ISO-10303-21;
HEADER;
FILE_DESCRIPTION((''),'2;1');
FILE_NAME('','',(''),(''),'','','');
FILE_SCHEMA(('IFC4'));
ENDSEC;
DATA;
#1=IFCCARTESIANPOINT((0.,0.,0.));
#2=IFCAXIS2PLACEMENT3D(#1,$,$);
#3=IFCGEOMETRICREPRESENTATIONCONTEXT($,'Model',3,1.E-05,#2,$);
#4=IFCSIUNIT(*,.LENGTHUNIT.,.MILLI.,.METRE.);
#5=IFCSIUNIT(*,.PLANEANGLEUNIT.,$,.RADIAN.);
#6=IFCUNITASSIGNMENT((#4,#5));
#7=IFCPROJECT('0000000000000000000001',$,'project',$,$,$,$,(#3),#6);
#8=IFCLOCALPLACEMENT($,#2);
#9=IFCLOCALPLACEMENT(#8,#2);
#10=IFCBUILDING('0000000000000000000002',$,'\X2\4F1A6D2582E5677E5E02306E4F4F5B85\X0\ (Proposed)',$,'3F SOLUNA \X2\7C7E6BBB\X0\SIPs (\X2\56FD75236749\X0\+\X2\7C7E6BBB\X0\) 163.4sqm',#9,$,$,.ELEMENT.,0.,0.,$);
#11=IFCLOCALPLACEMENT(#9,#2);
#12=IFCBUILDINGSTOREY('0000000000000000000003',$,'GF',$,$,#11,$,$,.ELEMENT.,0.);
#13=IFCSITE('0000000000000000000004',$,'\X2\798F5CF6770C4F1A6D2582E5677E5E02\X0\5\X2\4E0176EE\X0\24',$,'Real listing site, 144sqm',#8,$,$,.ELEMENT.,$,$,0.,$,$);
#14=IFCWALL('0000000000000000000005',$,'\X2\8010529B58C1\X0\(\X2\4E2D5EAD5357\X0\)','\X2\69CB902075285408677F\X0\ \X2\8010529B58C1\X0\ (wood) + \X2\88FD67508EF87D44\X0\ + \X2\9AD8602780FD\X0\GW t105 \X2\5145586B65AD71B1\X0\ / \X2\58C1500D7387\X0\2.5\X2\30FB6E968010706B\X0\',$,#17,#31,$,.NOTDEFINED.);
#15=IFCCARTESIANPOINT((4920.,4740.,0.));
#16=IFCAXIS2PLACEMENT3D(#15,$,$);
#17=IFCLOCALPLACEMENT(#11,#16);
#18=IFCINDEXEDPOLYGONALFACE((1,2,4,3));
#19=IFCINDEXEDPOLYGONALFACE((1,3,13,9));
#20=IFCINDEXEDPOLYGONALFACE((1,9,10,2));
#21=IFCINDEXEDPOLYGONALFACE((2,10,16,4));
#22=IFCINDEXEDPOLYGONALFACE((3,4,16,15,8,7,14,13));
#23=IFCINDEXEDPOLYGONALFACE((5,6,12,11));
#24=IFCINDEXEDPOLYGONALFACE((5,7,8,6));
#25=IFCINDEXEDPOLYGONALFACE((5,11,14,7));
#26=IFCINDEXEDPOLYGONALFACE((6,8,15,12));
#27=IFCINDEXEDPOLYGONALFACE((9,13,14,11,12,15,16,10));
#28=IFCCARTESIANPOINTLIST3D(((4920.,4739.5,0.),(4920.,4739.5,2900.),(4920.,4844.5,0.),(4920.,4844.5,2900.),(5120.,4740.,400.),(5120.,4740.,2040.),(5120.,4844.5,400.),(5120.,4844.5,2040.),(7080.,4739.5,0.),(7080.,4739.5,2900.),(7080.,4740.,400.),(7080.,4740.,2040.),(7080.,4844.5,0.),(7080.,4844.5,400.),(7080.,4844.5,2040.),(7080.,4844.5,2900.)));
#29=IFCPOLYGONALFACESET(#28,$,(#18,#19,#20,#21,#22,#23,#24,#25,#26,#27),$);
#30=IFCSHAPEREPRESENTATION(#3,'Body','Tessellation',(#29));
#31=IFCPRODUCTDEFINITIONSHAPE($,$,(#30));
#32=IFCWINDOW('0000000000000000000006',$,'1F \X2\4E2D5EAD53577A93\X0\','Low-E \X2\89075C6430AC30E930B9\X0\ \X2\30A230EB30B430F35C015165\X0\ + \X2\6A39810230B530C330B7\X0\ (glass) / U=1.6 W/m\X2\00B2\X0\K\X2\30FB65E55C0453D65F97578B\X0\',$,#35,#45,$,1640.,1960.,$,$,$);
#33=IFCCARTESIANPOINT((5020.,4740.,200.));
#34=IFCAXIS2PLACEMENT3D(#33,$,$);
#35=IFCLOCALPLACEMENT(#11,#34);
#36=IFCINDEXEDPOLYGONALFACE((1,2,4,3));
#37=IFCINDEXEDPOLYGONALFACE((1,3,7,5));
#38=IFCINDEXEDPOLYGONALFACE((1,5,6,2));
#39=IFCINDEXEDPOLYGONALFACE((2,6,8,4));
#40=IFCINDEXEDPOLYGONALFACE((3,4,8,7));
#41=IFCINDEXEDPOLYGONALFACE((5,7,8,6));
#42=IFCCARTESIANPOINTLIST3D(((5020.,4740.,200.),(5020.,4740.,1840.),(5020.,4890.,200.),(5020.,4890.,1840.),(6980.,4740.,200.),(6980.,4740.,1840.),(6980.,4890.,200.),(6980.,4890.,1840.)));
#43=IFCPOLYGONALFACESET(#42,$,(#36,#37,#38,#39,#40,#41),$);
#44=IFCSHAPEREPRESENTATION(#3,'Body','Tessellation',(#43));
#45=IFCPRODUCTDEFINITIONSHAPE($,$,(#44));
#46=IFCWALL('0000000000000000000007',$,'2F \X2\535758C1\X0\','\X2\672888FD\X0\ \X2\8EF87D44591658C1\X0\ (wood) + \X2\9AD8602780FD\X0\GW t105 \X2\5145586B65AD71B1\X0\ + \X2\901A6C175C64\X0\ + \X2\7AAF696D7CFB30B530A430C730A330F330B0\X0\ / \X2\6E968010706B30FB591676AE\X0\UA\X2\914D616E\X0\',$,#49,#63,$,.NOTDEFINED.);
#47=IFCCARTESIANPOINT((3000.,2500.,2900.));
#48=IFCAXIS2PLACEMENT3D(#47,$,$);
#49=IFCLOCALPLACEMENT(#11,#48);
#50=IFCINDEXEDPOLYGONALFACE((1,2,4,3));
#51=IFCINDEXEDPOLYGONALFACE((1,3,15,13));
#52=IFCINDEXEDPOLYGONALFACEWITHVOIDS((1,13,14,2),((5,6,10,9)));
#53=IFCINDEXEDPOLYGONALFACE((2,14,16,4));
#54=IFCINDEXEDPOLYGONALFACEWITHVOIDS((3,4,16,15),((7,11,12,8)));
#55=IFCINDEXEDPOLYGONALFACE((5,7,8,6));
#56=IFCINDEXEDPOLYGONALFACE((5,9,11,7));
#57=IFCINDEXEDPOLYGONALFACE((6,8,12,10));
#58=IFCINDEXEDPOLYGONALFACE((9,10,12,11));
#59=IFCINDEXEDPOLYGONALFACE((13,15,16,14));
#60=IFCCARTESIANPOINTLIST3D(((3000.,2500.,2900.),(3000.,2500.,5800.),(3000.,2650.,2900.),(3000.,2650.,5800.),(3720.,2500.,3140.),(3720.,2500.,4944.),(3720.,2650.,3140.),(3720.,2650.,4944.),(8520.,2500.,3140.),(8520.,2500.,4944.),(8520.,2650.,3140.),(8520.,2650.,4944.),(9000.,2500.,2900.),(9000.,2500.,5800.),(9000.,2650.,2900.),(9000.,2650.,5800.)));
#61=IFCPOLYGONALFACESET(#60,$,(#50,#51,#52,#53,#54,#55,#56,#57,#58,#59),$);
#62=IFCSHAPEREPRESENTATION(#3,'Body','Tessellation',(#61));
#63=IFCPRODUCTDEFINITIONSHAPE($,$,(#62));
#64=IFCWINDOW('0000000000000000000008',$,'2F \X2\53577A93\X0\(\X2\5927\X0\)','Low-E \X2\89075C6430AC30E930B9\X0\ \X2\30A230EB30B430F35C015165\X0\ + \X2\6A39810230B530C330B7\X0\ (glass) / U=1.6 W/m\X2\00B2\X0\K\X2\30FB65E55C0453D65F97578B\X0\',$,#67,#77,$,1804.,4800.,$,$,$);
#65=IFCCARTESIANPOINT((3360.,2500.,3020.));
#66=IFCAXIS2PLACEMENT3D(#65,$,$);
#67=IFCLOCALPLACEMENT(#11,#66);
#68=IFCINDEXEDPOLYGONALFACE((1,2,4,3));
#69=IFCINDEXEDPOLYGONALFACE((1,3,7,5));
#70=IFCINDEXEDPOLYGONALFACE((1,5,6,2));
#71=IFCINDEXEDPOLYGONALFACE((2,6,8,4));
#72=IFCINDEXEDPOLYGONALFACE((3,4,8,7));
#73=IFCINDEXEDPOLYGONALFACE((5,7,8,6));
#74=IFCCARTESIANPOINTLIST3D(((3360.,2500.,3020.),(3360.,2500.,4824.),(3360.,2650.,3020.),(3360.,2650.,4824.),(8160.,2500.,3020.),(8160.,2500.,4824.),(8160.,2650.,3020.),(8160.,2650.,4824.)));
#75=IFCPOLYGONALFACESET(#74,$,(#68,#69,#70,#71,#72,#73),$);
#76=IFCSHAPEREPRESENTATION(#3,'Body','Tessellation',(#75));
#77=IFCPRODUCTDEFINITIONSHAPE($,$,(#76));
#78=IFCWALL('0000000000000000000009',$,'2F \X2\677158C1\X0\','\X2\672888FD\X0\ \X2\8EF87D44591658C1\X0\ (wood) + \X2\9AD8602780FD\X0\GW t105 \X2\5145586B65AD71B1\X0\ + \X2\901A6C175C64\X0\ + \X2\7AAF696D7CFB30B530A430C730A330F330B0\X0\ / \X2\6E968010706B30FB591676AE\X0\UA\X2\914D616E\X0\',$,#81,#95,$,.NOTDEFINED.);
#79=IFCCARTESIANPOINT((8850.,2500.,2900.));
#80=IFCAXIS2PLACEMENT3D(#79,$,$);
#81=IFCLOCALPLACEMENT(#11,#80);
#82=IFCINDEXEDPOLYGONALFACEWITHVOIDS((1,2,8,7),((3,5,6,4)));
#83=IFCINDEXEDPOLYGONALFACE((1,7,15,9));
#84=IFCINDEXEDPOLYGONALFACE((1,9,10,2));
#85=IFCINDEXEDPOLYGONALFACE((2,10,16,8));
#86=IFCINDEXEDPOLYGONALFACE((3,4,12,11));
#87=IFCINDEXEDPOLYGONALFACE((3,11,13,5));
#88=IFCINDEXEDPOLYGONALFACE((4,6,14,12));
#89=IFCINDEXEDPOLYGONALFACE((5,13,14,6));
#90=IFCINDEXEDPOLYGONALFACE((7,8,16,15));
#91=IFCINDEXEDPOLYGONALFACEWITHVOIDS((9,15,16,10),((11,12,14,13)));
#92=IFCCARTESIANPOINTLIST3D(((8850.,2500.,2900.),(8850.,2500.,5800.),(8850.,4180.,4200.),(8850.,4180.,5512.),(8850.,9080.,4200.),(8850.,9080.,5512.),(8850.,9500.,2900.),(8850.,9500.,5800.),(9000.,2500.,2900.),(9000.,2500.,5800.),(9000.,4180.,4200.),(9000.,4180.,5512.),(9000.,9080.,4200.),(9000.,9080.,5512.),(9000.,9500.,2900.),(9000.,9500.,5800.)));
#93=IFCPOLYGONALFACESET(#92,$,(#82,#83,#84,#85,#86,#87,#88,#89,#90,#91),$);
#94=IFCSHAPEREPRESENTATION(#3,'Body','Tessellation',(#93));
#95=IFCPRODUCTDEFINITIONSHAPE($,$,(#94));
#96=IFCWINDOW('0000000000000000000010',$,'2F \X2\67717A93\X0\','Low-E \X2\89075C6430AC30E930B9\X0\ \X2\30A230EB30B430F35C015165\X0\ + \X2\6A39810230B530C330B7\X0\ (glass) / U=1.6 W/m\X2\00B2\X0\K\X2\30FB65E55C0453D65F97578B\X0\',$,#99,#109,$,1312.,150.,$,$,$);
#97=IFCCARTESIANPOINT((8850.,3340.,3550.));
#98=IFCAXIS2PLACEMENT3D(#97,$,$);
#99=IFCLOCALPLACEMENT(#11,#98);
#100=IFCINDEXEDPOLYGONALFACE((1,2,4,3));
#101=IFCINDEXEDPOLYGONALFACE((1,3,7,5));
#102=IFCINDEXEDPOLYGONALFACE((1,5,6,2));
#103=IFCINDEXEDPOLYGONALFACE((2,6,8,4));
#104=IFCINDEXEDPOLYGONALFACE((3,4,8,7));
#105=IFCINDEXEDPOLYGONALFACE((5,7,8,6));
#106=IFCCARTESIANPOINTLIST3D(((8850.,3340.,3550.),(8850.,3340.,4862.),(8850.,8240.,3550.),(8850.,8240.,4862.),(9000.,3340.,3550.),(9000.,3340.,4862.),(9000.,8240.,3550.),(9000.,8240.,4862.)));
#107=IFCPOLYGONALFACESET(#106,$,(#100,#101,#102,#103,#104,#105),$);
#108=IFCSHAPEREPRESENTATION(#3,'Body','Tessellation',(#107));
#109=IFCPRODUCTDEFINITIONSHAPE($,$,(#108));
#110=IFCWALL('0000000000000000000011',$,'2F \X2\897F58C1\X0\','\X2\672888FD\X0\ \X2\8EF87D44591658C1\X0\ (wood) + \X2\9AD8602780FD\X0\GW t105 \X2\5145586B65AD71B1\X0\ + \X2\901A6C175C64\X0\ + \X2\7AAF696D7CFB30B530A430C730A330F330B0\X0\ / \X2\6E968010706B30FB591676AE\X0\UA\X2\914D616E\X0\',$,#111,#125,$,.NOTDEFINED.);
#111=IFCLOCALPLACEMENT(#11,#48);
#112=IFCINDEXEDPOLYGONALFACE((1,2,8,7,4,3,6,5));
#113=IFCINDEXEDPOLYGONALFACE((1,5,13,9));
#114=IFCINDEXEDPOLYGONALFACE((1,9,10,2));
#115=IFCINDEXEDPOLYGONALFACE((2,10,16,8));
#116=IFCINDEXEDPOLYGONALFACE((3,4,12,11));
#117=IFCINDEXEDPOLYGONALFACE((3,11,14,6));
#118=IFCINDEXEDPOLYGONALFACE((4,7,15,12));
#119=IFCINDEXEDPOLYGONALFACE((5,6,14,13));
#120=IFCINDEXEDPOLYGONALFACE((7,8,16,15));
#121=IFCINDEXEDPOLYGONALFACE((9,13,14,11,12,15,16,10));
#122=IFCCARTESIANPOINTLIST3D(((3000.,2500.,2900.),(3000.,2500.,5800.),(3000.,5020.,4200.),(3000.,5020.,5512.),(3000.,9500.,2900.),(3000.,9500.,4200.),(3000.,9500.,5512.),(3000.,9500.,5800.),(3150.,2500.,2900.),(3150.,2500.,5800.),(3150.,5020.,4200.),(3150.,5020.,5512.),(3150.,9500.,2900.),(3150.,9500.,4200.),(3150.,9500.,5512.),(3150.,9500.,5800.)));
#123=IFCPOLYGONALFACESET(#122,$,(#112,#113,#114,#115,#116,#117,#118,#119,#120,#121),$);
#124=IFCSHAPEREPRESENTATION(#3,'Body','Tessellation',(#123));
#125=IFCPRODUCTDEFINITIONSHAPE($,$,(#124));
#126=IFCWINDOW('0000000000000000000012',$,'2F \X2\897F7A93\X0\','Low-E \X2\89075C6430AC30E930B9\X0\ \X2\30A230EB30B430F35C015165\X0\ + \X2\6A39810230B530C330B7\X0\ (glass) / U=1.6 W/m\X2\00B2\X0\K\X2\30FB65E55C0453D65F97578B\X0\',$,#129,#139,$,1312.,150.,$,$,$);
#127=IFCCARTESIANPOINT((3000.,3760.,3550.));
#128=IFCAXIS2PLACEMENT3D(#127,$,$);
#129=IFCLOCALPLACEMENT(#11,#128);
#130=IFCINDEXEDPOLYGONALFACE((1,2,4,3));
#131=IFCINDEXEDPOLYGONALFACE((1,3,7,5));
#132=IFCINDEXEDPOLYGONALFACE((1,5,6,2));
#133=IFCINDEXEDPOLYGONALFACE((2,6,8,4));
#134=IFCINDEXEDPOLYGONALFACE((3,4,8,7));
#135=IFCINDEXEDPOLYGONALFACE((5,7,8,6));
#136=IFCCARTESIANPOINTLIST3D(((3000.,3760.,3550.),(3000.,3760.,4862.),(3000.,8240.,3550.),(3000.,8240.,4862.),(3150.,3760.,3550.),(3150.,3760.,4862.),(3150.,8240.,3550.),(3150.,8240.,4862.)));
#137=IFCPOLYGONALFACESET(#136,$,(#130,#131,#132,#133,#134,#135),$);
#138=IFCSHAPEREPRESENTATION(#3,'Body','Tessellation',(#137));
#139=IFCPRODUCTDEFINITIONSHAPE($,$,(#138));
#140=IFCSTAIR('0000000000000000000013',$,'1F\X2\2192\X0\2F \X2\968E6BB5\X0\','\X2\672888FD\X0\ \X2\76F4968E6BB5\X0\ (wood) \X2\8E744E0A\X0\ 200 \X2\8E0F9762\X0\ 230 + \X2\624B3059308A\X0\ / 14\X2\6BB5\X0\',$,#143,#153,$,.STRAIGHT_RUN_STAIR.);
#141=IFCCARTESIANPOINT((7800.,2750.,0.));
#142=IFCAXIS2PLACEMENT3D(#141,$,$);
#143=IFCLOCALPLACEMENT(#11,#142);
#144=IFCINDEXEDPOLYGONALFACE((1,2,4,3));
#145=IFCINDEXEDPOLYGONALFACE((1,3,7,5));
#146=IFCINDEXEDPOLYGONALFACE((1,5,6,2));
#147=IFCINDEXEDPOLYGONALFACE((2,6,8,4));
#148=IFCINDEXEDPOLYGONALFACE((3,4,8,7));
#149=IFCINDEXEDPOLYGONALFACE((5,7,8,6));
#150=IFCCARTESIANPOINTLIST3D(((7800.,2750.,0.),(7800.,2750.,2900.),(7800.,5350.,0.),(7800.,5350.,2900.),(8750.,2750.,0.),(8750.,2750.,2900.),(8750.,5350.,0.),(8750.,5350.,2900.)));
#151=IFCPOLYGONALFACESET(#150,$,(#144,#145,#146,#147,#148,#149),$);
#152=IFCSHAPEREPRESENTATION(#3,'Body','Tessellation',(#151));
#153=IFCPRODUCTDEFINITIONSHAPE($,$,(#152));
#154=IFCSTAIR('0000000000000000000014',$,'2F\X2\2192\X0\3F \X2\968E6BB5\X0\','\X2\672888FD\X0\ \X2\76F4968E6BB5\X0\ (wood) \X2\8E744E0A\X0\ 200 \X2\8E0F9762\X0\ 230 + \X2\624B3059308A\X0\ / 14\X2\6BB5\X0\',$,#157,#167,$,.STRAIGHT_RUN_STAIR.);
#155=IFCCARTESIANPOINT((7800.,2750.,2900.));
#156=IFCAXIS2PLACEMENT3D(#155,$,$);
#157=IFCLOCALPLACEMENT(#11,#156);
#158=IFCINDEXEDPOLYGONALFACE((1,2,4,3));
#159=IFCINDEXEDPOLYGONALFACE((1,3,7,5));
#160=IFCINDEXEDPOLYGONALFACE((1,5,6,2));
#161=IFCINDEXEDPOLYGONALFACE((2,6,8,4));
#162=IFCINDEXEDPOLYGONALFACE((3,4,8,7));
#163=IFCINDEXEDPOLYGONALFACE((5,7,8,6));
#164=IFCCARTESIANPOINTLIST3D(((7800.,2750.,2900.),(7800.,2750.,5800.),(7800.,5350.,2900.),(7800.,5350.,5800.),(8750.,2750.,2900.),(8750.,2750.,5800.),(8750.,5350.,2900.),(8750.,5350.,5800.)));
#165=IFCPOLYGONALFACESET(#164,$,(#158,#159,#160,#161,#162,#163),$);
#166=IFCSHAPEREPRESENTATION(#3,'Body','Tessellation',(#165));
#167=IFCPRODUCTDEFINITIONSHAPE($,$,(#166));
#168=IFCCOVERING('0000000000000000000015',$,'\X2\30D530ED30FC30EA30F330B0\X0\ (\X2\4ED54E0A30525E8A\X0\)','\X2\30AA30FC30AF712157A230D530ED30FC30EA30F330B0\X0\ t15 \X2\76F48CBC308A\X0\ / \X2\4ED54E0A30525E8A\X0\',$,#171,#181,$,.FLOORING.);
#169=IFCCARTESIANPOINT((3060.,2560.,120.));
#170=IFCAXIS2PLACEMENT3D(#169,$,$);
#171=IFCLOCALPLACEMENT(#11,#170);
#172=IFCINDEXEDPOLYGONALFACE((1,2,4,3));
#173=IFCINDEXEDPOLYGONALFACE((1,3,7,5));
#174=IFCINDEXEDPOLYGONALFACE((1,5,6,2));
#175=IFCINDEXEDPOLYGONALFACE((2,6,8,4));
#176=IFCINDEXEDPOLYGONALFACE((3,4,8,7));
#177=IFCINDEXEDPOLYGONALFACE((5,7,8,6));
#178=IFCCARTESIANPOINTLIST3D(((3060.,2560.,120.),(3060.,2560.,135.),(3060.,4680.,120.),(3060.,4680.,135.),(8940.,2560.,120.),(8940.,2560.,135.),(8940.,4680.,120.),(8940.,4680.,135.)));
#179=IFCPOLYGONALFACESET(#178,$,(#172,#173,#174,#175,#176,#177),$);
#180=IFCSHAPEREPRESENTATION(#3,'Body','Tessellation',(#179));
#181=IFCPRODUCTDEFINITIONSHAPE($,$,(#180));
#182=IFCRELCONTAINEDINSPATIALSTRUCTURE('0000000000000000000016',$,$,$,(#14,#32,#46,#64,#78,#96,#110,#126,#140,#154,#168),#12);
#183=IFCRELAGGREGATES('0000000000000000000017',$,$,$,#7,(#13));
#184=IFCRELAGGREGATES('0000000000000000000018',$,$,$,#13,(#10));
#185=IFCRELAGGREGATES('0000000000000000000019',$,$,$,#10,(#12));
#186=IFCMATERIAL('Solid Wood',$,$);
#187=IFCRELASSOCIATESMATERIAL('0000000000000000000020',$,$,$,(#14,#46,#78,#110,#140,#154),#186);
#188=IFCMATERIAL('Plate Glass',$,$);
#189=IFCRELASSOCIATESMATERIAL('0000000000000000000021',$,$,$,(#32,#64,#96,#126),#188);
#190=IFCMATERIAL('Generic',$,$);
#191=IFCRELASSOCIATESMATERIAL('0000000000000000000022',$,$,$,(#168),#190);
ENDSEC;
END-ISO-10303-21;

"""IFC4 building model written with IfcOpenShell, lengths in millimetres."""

from ifc_helpers import new_model, si_unit, frame, frame_2d, origin, place, context, project, spatial, rectangle, extrude, material, element, fill, save


model = new_model("IFC4")

# Units and contexts
model_context = context("Model", 3, precision=1e-05, world=origin())
ifc_project = project(units=[si_unit("LENGTHUNIT", "METRE", prefix="MILLI"), si_unit("PLANEANGLEUNIT", "RADIAN")], contexts=[model_context])

# Site, building, storey
site_placement = place(None, origin())
site = spatial("IfcSite", under=ifc_project, at=site_placement, Name="福島県会津若松市5丁目24", ObjectType="Real listing site, 144sqm", CompositionType="ELEMENT", RefElevation=0.0)
building_placement = place(site_placement, origin())
building = spatial("IfcBuilding", under=site, at=building_placement, Name="会津若松市の住宅 (Proposed)", ObjectType="3F SOLUNA 籾殻SIPs (国産杉+籾殻) 163.4sqm", CompositionType="ELEMENT", ElevationOfRefHeight=0.0, ElevationOfTerrain=0.0)
storey_placement = place(building_placement, origin())
storey = spatial("IfcBuildingStorey", under=building, at=storey_placement, Name="GF", CompositionType="ELEMENT", Elevation=0.0)

# Shared definitions
ifc_material_1 = material(Name="Solid Wood")
ifc_material_2 = material(Name="Generic")

# Shared definitions
ifc_material_3 = material(Name="Plate Glass")

# Walls, openings, windows
wall_1_placement = place(storey_placement, frame((4920.0, 4740.0, 0.0)))
wall_1 = element("IfcWall", 1, at=wall_1_placement, inside=storey, material=ifc_material_1, Name="耐力壁(中庭南)", Description="構造用合板 耐力壁 (wood) + 製材軸組 + 高性能GW t105 充填断熱 / 壁倍率2.5・準耐火", PredefinedType="NOTDEFINED", context=model_context, shape_type="SweptSolid", body=[
    extrude(rectangle(XDim=2160.0, YDim=105.0, at=frame_2d((1080.0, 52.0))), frame((4920.0, 4740.0, 0.0)), (0.0, 0.0, 1.0), 2900.0),
])
opening_1_placement = place(storey_placement, frame((5020.0, 4740.0, 200.0)))
opening_1 = element("IfcOpeningElement", 2, at=opening_1_placement, cuts=wall_1, PredefinedType="NOTDEFINED", context=model_context, shape_type="SweptSolid", body=[
    extrude(rectangle(XDim=1960.0, YDim=150.0, at=frame_2d((980.0, 75.0))), frame((5020.0, 4740.0, 200.0)), (0.0, 0.0, 1.0), 1640.0),
])
window_1_placement = place(storey_placement, frame((5020.0, 4740.0, 200.0)))
window_1 = element("IfcWindow", 3, at=window_1_placement, inside=storey, material=ifc_material_3, Name="1F 中庭南窓", Description="Low-E 複層ガラス アルゴン封入 + 樹脂サッシ (glass) / U=1.6 W/m²K・日射取得型", OverallHeight=1640.0, OverallWidth=1960.0, context=model_context, shape_type="SweptSolid", body=[
    extrude(rectangle(XDim=1960.0, YDim=150.0, at=frame_2d((980.0, 75.0))), frame((5020.0, 4740.0, 200.0)), (0.0, 0.0, 1.0), 1640.0),
])
fill(opening_1, window_1)
wall_2_placement = place(storey_placement, frame((3000.0, 2500.0, 2900.0)))
wall_2 = element("IfcWall", 4, at=wall_2_placement, inside=storey, material=ifc_material_1, Name="2F 南壁", Description="木製 軸組外壁 (wood) + 高性能GW t105 充填断熱 + 通気層 + 窯業系サイディング / 準耐火・外皮UA配慮", PredefinedType="NOTDEFINED", context=model_context, shape_type="SweptSolid", body=[
    extrude(rectangle(XDim=6000.0, YDim=150.0, at=frame_2d((3000.0, 75.0))), frame((3000.0, 2500.0, 2900.0)), (0.0, 0.0, 1.0), 2900.0),
])
opening_2_placement = place(storey_placement, frame((3360.0, 2500.0, 3020.0)))
opening_2 = element("IfcOpeningElement", 5, at=opening_2_placement, cuts=wall_2, PredefinedType="NOTDEFINED", context=model_context, shape_type="SweptSolid", body=[
    extrude(rectangle(XDim=4800.0, YDim=150.0, at=frame_2d((2400.0, 75.0))), frame((3360.0, 2500.0, 3020.0)), (0.0, 0.0, 1.0), 1804.0),
])
window_2_placement = place(storey_placement, frame((3360.0, 2500.0, 3020.0)))
window_2 = element("IfcWindow", 6, at=window_2_placement, inside=storey, material=ifc_material_3, Name="2F 南窓(大)", Description="Low-E 複層ガラス アルゴン封入 + 樹脂サッシ (glass) / U=1.6 W/m²K・日射取得型", OverallHeight=1804.0, OverallWidth=4800.0, context=model_context, shape_type="SweptSolid", body=[
    extrude(rectangle(XDim=4800.0, YDim=150.0, at=frame_2d((2400.0, 75.0))), frame((3360.0, 2500.0, 3020.0)), (0.0, 0.0, 1.0), 1804.0),
])
fill(opening_2, window_2)
wall_3_placement = place(storey_placement, frame((8850.0, 2500.0, 2900.0)))
wall_3 = element("IfcWall", 7, at=wall_3_placement, inside=storey, material=ifc_material_1, Name="2F 東壁", Description="木製 軸組外壁 (wood) + 高性能GW t105 充填断熱 + 通気層 + 窯業系サイディング / 準耐火・外皮UA配慮", PredefinedType="NOTDEFINED", context=model_context, shape_type="SweptSolid", body=[
    extrude(rectangle(XDim=150.0, YDim=7000.0, at=frame_2d((75.0, 3500.0))), frame((8850.0, 2500.0, 2900.0)), (0.0, 0.0, 1.0), 2900.0),
])
opening_3_placement = place(storey_placement, frame((8850.0, 3340.0, 3550.0)))
opening_3 = element("IfcOpeningElement", 8, at=opening_3_placement, cuts=wall_3, PredefinedType="NOTDEFINED", context=model_context, shape_type="SweptSolid", body=[
    extrude(rectangle(XDim=150.0, YDim=4900.0, at=frame_2d((75.0, 2450.0))), frame((8850.0, 3340.0, 3550.0)), (0.0, 0.0, 1.0), 1312.0),
])
window_3_placement = place(storey_placement, frame((8850.0, 3340.0, 3550.0)))
window_3 = element("IfcWindow", 9, at=window_3_placement, inside=storey, material=ifc_material_3, Name="2F 東窓", Description="Low-E 複層ガラス アルゴン封入 + 樹脂サッシ (glass) / U=1.6 W/m²K・日射取得型", OverallHeight=1312.0, OverallWidth=150.0, context=model_context, shape_type="SweptSolid", body=[
    extrude(rectangle(XDim=150.0, YDim=4900.0, at=frame_2d((75.0, 2450.0))), frame((8850.0, 3340.0, 3550.0)), (0.0, 0.0, 1.0), 1312.0),
])
fill(opening_3, window_3)
wall_4_placement = place(storey_placement, frame((3000.0, 2500.0, 2900.0)))
wall_4 = element("IfcWall", 10, at=wall_4_placement, inside=storey, material=ifc_material_1, Name="2F 西壁", Description="木製 軸組外壁 (wood) + 高性能GW t105 充填断熱 + 通気層 + 窯業系サイディング / 準耐火・外皮UA配慮", PredefinedType="NOTDEFINED", context=model_context, shape_type="SweptSolid", body=[
    extrude(rectangle(XDim=150.0, YDim=7000.0, at=frame_2d((75.0, 3500.0))), frame((3000.0, 2500.0, 2900.0)), (0.0, 0.0, 1.0), 2900.0),
])
opening_4_placement = place(storey_placement, frame((3000.0, 3760.0, 3550.0)))
opening_4 = element("IfcOpeningElement", 11, at=opening_4_placement, cuts=wall_4, PredefinedType="NOTDEFINED", context=model_context, shape_type="SweptSolid", body=[
    extrude(rectangle(XDim=150.0, YDim=4480.0, at=frame_2d((75.0, 2240.0))), frame((3000.0, 3760.0, 3550.0)), (0.0, 0.0, 1.0), 1312.0),
])
window_4_placement = place(storey_placement, frame((3000.0, 3760.0, 3550.0)))
window_4 = element("IfcWindow", 12, at=window_4_placement, inside=storey, material=ifc_material_3, Name="2F 西窓", Description="Low-E 複層ガラス アルゴン封入 + 樹脂サッシ (glass) / U=1.6 W/m²K・日射取得型", OverallHeight=1312.0, OverallWidth=150.0, context=model_context, shape_type="SweptSolid", body=[
    extrude(rectangle(XDim=150.0, YDim=4480.0, at=frame_2d((75.0, 2240.0))), frame((3000.0, 3760.0, 3550.0)), (0.0, 0.0, 1.0), 1312.0),
])
fill(opening_4, window_4)

# Stairs
stair_1_placement = place(storey_placement, frame((7800.0, 2750.0, 0.0)))
element("IfcStair", 13, at=stair_1_placement, inside=storey, material=ifc_material_1, Name="1F→2F 階段", Description="木製 直階段 (wood) 蹴上 200 踏面 230 + 手すり / 14段", PredefinedType="STRAIGHT_RUN_STAIR", context=model_context, shape_type="SweptSolid", body=[
    extrude(rectangle(XDim=950.0, YDim=2600.0, at=frame_2d((475.0, 1300.0))), frame((7800.0, 2750.0, 0.0)), (0.0, 0.0, 1.0), 2900.0),
])
stair_2_placement = place(storey_placement, frame((7800.0, 2750.0, 2900.0)))
element("IfcStair", 14, at=stair_2_placement, inside=storey, material=ifc_material_1, Name="2F→3F 階段", Description="木製 直階段 (wood) 蹴上 200 踏面 230 + 手すり / 14段", PredefinedType="STRAIGHT_RUN_STAIR", context=model_context, shape_type="SweptSolid", body=[
    extrude(rectangle(XDim=950.0, YDim=2600.0, at=frame_2d((475.0, 1300.0))), frame((7800.0, 2750.0, 2900.0)), (0.0, 0.0, 1.0), 2900.0),
])

# Covering
covering_placement = place(storey_placement, frame((3060.0, 2560.0, 120.0)))
element("IfcCovering", 15, at=covering_placement, inside=storey, material=ifc_material_2, Name="フローリング (仕上げ床)", Description="オーク無垢フローリング t15 直貼り / 仕上げ床", PredefinedType="FLOORING", context=model_context, shape_type="SweptSolid", body=[
    extrude(rectangle(XDim=5880.0, YDim=2120.0, at=frame_2d((2940.0, 1060.0))), frame((3060.0, 2560.0, 120.0)), (0.0, 0.0, 1.0), 15.0),
])

save(model, "model.ifc")
